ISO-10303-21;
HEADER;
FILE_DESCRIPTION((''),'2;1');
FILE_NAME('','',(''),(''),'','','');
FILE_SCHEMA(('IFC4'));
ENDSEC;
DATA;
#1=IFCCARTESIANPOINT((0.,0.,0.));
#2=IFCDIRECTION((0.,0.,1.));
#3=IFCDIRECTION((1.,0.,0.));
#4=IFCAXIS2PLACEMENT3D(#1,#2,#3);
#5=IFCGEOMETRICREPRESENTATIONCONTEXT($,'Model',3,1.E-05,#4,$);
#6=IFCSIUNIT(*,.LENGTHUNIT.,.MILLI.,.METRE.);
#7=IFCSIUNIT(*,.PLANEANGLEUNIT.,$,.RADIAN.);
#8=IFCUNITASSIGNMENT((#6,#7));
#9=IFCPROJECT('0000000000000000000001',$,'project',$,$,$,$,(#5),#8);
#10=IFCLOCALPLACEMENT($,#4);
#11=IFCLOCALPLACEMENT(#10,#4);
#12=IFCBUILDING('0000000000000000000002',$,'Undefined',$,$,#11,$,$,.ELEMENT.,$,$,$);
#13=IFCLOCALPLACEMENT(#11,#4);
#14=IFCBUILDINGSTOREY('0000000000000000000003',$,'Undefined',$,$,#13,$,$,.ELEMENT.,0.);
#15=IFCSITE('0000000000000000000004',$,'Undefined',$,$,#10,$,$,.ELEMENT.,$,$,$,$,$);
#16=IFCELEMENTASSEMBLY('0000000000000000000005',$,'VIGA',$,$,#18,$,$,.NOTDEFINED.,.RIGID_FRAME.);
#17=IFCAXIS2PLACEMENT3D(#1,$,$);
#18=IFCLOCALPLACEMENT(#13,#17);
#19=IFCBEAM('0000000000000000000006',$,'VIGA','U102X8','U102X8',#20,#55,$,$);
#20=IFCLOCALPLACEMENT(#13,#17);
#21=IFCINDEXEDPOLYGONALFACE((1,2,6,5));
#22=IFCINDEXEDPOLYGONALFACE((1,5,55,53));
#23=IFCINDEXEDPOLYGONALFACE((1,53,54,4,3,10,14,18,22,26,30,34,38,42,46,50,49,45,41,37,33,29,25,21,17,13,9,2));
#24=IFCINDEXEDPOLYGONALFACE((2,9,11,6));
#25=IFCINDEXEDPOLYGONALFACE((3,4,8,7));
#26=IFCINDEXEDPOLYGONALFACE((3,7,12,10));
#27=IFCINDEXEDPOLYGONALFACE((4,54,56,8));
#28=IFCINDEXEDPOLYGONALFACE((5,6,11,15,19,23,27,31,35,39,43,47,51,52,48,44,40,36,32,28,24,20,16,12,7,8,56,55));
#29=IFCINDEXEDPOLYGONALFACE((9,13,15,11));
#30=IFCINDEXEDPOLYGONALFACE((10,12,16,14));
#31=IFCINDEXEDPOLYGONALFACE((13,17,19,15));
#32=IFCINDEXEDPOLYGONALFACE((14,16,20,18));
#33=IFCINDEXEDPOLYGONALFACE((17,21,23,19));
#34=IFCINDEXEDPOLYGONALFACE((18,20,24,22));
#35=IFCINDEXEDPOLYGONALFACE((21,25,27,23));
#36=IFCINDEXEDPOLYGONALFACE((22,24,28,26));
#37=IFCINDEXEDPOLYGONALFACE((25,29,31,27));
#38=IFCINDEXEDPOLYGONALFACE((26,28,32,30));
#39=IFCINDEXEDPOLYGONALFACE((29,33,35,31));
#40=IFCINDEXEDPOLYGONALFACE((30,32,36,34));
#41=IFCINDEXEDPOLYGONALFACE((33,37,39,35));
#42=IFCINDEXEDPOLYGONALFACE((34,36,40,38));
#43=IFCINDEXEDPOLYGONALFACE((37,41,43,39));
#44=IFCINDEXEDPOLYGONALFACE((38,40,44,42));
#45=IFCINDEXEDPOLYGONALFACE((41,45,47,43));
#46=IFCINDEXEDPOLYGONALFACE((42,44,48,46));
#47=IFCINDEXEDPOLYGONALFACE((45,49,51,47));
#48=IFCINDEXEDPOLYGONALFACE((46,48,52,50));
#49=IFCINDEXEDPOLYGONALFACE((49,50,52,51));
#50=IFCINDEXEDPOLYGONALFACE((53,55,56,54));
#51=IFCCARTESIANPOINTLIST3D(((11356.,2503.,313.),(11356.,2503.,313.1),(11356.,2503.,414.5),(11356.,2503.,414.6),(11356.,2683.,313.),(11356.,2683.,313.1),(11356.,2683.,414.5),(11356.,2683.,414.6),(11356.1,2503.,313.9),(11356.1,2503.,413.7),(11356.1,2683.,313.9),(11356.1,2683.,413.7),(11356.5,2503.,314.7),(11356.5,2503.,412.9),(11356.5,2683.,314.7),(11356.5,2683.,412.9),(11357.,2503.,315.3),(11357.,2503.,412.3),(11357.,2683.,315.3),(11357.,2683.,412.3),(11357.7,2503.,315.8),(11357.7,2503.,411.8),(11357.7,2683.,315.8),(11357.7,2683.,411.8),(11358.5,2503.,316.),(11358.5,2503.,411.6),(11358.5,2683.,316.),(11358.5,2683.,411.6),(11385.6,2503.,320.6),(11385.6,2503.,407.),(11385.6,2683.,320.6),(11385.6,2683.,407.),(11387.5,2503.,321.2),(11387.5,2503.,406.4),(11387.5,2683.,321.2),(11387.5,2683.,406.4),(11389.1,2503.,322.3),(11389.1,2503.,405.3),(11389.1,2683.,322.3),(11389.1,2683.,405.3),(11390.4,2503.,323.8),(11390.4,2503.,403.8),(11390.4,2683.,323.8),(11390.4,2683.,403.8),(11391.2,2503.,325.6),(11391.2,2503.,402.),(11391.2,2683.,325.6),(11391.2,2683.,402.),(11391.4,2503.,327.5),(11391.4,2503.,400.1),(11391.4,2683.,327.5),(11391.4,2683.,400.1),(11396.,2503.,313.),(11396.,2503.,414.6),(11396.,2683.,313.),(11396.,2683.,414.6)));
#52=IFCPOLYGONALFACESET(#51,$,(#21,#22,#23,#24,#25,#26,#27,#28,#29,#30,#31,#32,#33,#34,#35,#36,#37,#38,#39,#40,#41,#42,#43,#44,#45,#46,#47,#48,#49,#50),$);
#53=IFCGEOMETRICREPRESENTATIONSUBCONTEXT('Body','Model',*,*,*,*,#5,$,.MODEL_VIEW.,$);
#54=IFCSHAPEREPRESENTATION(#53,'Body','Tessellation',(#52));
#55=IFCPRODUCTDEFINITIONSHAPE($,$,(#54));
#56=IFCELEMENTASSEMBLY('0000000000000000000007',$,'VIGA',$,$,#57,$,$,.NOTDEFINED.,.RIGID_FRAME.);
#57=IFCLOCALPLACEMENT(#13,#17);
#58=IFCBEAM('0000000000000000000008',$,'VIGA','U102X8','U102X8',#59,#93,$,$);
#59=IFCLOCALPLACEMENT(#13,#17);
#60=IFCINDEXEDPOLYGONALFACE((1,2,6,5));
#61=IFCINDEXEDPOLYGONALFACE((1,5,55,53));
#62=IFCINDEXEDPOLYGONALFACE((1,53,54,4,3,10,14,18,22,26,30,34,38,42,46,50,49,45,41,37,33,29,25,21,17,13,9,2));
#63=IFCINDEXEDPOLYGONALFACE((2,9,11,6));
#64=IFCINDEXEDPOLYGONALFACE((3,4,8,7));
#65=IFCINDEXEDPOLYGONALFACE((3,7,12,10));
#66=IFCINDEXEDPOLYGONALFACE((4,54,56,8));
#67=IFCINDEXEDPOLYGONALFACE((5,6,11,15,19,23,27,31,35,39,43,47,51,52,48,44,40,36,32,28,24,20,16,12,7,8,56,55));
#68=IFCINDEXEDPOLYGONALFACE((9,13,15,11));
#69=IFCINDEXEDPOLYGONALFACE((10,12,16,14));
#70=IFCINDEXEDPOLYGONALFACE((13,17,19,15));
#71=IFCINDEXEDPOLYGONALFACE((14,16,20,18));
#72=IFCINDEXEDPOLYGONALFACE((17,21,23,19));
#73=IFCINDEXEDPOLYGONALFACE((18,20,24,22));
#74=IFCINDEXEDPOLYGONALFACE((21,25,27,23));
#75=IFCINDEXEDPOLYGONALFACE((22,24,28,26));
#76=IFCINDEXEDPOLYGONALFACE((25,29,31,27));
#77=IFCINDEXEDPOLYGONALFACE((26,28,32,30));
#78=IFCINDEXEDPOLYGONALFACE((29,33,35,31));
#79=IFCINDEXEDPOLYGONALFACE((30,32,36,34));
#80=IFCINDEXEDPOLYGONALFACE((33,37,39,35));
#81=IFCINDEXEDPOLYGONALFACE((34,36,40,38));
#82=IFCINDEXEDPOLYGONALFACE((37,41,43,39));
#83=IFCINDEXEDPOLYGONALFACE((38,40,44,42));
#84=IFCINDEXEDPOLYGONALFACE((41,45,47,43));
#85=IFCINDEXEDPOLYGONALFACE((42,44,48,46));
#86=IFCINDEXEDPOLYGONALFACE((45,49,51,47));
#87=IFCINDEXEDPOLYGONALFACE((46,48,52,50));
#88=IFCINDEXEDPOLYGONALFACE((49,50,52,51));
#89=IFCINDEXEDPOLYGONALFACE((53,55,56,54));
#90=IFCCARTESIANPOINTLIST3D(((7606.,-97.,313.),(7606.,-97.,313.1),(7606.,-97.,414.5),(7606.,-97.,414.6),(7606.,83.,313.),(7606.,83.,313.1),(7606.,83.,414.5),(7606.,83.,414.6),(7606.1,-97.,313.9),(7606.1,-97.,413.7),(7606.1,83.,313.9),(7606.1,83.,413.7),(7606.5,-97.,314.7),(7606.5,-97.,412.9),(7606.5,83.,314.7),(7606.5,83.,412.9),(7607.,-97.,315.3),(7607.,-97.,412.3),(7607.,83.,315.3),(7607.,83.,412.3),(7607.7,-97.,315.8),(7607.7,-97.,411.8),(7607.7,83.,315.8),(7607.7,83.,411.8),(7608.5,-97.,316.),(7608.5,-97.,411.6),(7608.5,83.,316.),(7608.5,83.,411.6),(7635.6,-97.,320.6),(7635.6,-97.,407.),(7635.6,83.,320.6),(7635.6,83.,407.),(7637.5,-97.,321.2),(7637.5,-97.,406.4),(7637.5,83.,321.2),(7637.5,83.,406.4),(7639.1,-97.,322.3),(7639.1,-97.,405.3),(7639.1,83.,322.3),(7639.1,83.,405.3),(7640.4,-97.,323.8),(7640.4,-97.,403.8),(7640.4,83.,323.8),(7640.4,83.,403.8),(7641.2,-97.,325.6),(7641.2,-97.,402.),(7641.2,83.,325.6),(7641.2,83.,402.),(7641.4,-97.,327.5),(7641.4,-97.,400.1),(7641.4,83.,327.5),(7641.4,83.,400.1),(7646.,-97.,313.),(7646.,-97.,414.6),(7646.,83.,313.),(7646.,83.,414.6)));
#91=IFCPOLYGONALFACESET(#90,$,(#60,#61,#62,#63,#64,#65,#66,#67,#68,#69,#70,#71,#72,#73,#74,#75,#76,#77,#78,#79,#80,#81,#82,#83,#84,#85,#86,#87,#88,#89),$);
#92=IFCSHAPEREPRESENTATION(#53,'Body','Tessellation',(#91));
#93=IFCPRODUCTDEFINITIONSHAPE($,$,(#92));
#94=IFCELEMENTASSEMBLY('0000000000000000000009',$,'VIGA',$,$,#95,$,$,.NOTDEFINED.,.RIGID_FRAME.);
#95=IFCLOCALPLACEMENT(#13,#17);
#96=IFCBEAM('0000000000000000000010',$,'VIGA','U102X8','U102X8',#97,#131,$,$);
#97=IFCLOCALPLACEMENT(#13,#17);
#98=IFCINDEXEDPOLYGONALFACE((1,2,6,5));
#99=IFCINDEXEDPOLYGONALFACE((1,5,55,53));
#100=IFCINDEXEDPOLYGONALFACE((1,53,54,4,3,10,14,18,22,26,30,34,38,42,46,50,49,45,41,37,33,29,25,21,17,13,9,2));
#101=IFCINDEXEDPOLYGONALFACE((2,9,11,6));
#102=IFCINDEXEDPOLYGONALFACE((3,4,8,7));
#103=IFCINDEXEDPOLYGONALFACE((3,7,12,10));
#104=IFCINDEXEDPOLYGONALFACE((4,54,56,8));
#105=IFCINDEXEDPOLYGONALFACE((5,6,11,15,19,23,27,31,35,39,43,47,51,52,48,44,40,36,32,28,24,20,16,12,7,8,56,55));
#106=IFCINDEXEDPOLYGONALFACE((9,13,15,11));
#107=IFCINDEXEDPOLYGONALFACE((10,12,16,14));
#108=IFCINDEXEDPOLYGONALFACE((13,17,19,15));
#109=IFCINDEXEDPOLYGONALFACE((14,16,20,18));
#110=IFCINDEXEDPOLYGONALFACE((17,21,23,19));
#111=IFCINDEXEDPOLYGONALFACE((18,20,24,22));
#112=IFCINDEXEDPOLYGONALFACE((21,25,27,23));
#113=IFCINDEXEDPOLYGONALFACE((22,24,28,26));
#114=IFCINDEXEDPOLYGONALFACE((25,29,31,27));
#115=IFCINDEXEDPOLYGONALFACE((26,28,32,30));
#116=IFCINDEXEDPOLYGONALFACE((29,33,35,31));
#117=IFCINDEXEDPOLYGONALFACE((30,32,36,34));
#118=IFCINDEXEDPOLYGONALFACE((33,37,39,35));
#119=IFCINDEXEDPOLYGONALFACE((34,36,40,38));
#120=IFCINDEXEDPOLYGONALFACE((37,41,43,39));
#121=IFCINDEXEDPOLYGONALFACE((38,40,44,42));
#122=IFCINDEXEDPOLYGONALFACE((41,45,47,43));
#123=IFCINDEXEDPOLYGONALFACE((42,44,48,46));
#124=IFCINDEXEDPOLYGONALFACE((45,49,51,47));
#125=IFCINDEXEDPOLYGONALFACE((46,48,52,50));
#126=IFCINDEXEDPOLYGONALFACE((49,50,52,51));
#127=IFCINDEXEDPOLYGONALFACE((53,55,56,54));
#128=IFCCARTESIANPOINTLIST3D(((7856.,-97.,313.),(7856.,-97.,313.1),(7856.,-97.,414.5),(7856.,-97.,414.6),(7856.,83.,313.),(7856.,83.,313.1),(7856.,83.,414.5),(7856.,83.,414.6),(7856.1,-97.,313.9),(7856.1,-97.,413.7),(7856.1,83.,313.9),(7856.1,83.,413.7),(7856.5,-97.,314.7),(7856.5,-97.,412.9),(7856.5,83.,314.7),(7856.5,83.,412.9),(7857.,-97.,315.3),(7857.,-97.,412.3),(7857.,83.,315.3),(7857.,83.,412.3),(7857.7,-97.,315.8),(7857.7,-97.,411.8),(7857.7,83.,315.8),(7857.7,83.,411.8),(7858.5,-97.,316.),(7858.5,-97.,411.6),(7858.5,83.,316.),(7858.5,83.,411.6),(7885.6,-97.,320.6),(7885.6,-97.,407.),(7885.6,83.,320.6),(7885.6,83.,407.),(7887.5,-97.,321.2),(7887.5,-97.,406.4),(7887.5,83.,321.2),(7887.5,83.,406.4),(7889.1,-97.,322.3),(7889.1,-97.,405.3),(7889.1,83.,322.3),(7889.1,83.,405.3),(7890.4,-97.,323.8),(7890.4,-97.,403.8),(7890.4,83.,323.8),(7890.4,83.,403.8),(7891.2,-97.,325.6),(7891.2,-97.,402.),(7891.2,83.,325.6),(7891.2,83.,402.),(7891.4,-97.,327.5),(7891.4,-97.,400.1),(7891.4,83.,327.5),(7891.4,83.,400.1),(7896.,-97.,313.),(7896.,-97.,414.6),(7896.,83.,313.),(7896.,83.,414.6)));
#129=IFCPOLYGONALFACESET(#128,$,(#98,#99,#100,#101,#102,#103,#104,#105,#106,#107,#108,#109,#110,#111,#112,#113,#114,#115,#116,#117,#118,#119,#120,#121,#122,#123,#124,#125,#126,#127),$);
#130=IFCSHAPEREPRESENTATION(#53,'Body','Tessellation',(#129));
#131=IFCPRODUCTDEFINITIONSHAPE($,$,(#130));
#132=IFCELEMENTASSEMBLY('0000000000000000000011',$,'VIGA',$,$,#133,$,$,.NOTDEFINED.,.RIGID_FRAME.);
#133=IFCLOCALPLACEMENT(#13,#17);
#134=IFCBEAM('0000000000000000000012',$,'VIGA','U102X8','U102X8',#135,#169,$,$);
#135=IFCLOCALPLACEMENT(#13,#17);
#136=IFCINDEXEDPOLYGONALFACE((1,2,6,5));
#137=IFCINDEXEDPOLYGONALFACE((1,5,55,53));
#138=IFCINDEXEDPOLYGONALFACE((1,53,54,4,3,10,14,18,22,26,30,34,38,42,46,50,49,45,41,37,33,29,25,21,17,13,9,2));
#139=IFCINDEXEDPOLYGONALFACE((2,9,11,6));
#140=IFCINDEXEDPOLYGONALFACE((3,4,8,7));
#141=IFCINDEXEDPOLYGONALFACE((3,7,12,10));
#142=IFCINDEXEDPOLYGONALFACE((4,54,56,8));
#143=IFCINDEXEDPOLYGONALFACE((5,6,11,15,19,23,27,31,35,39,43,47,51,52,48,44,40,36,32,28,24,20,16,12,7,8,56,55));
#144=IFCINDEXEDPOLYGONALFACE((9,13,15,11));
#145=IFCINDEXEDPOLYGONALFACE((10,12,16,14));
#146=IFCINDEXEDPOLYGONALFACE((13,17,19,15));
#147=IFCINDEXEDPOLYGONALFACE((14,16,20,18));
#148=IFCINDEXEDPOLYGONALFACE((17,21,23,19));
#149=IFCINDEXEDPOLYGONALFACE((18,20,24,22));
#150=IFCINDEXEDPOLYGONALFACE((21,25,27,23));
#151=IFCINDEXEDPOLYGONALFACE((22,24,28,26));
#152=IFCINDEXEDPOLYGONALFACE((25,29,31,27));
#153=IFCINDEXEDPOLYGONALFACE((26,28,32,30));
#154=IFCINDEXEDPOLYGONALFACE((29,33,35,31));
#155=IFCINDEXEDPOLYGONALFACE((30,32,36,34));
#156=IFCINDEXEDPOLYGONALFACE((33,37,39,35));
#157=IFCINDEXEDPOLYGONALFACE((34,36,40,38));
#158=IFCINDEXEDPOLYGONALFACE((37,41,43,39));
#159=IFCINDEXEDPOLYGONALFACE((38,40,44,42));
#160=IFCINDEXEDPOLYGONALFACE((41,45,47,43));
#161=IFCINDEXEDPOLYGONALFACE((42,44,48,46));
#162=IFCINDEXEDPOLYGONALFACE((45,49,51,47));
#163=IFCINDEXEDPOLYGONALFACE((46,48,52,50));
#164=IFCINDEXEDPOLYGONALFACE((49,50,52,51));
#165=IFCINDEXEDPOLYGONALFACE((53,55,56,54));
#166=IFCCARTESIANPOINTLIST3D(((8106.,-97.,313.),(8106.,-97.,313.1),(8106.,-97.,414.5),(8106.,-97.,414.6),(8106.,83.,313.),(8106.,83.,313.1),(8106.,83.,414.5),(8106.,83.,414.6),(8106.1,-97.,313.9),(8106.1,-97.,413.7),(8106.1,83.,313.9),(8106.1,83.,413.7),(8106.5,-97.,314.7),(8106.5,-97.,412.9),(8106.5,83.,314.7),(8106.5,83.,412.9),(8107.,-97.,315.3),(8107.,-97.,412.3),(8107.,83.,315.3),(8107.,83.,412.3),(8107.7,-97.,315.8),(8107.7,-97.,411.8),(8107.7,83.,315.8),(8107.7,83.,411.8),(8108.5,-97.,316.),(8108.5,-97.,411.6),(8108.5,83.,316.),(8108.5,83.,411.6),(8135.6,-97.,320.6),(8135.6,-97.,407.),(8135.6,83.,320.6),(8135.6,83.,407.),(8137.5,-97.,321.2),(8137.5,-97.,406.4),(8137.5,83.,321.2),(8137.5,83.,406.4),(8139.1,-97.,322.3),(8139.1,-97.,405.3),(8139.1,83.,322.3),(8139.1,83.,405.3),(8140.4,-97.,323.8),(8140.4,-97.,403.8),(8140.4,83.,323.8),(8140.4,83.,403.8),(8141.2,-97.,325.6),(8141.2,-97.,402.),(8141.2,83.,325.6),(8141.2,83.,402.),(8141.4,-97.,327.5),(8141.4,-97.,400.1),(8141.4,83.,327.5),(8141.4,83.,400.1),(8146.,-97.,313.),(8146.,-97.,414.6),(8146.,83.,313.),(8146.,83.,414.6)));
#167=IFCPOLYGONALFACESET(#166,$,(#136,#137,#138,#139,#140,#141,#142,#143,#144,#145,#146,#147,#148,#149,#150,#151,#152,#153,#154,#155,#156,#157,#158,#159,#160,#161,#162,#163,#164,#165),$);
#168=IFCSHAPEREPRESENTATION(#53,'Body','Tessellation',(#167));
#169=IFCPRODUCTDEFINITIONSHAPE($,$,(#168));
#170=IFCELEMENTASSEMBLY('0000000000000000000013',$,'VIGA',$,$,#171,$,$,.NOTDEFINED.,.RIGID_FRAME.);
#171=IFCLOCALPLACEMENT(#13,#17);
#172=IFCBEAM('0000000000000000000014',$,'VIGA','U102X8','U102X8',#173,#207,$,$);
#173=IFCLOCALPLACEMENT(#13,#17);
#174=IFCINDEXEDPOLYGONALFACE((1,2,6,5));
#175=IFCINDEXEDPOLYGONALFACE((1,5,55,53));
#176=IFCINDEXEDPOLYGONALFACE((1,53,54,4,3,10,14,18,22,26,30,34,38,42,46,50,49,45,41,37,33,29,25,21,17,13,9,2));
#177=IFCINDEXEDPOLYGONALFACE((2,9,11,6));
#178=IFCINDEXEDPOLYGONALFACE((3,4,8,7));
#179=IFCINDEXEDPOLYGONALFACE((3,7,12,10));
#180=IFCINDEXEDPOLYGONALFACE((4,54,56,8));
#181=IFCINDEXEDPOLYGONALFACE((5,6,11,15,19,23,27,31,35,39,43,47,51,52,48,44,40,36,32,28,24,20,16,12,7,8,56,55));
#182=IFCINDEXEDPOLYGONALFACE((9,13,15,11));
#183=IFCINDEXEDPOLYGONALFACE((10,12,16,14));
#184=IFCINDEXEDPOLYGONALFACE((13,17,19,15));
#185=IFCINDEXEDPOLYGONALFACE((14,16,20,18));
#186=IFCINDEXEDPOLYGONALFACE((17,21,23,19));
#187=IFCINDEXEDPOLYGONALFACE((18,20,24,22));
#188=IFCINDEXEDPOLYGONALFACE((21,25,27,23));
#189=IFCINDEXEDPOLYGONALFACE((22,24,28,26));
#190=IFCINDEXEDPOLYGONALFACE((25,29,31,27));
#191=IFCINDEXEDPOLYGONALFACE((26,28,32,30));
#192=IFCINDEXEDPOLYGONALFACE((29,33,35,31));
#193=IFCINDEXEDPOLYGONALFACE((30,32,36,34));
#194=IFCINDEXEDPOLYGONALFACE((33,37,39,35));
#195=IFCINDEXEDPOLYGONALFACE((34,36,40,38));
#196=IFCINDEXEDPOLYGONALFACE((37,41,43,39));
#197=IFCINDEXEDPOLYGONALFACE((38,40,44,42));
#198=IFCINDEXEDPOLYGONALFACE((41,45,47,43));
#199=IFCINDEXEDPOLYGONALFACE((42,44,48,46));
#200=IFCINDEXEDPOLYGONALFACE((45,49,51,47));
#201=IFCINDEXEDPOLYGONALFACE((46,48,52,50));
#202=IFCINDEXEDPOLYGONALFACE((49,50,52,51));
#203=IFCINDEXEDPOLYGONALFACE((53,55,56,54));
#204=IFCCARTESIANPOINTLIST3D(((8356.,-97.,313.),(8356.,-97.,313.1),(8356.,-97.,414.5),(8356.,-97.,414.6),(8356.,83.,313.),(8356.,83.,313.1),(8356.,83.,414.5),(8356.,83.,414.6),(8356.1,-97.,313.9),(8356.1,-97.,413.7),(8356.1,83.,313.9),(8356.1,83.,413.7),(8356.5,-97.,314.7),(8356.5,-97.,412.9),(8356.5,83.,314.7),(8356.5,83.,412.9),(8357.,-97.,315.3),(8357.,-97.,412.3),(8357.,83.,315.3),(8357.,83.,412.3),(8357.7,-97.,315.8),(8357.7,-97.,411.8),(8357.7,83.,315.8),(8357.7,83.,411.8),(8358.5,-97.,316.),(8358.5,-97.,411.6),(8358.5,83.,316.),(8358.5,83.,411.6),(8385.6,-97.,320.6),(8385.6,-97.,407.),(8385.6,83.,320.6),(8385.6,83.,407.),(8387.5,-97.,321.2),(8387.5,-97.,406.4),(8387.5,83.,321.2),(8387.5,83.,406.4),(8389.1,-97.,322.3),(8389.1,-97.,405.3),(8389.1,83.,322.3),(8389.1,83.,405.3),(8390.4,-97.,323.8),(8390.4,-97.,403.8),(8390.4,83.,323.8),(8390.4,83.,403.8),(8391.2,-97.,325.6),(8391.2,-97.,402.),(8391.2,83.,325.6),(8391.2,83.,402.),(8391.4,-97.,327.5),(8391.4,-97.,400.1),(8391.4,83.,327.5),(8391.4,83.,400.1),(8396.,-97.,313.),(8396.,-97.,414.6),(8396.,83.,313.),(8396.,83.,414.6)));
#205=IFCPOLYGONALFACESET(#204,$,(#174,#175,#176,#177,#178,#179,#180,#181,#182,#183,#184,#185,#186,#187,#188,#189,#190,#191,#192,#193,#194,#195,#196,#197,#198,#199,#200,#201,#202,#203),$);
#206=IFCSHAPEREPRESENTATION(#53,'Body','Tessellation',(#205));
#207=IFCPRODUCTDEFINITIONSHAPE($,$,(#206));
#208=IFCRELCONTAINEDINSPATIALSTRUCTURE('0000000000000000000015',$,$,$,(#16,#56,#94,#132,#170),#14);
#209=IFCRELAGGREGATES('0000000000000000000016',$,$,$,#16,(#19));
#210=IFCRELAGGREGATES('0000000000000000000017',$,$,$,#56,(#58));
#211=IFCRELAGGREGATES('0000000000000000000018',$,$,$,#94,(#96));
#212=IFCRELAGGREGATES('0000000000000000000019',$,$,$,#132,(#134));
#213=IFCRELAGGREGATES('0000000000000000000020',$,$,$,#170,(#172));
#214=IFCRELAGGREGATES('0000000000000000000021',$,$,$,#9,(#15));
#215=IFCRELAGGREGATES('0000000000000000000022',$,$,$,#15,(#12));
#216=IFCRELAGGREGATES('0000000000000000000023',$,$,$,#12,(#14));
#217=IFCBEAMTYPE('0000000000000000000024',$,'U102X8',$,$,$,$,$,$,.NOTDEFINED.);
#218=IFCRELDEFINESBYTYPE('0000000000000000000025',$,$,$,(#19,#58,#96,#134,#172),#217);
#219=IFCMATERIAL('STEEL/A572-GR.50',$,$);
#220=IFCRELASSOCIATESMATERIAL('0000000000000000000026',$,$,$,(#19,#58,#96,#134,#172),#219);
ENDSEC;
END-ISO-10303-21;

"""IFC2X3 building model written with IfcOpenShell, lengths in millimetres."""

from ifc_helpers import new_model, si_unit, frame, origin_with_axes, origin_2d_with_axis, place, context, subcontext, project, spatial, u_section, extrude, material, type_object, element, aggregate, save


model = new_model("IFC2X3")

# Units and contexts
model_context = context("Model", 3, precision=1e-05, world=origin_with_axes())
body_context = subcontext(model_context, "Body", "Model", "MODEL_VIEW")
ifc_project = project(units=[si_unit("LENGTHUNIT", "METRE", prefix="MILLI"), si_unit("PLANEANGLEUNIT", "RADIAN")], contexts=[model_context])

# Site, building, storey
site_placement = place(None, origin_with_axes())
site = spatial("IfcSite", under=ifc_project, at=site_placement, Name="Undefined", CompositionType="ELEMENT")
building_placement = place(site_placement, origin_with_axes())
building = spatial("IfcBuilding", under=site, at=building_placement, Name="Undefined", CompositionType="ELEMENT")
storey_placement = place(building_placement, origin_with_axes())
storey = spatial("IfcBuildingStorey", under=building, at=storey_placement, Name="Undefined", CompositionType="ELEMENT", Elevation=0.0)

# Element assemblies, beams
ifc_material_1 = material(Name="STEEL/A572-GR.50")
beam_type = type_object("IfcBeamType", Name="U102X8", PredefinedType="NOTDEFINED")
assembly_1_placement = place(storey_placement, origin_with_axes())
assembly_1 = element("IfcElementAssembly", 1, at=assembly_1_placement, inside=storey, Name="VIGA", AssemblyPlace="NOTDEFINED", PredefinedType="RIGID_FRAME")
beam_1_placement = place(assembly_1_placement, frame((11376.0, 2683.0, 363.8), z_axis=(0.0, 0.0, 1.0), x_axis=(0.0, -1.0, 0.0)))
beam_1 = element("IfcBeam", 2, at=beam_1_placement, type_object=beam_type, material=ifc_material_1, Name="VIGA", Description="U102X8", ObjectType="U102X8", context=body_context, shape_type="SweptSolid", body=[
    extrude(u_section(Depth=101.6, FlangeWidth=40.0, WebThickness=4.6, FlangeThickness=6.0, FilletRadius=7.0, EdgeRadius=3.0, FlangeSlope=0.16839, at=origin_2d_with_axis()), frame((180.0, 0.0, 0.0), z_axis=(-1.0, 0.0, 0.0), x_axis=(0.0, -1.0, 0.0)), (0.0, 0.0, 1.0), 180.0),
])
aggregate(assembly_1, [beam_1])
assembly_2_placement = place(storey_placement, origin_with_axes())
assembly_2 = element("IfcElementAssembly", 3, at=assembly_2_placement, inside=storey, Name="VIGA", AssemblyPlace="NOTDEFINED", PredefinedType="RIGID_FRAME")
beam_2_placement = place(assembly_2_placement, frame((7626.0, 83.0, 363.8), z_axis=(0.0, 0.0, 1.0), x_axis=(0.0, -1.0, 0.0)))
beam_2 = element("IfcBeam", 4, at=beam_2_placement, type_object=beam_type, material=ifc_material_1, Name="VIGA", Description="U102X8", ObjectType="U102X8", context=body_context, shape_type="SweptSolid", body=[
    extrude(u_section(Depth=101.6, FlangeWidth=40.0, WebThickness=4.6, FlangeThickness=6.0, FilletRadius=7.0, EdgeRadius=3.0, FlangeSlope=0.16839, at=origin_2d_with_axis()), frame((180.0, 0.0, 0.0), z_axis=(-1.0, 0.0, 0.0), x_axis=(0.0, -1.0, 0.0)), (0.0, 0.0, 1.0), 180.0),
])
aggregate(assembly_2, [beam_2])
assembly_3_placement = place(storey_placement, origin_with_axes())
assembly_3 = element("IfcElementAssembly", 5, at=assembly_3_placement, inside=storey, Name="VIGA", AssemblyPlace="NOTDEFINED", PredefinedType="RIGID_FRAME")
beam_3_placement = place(assembly_3_placement, frame((7876.0, 83.0, 363.8), z_axis=(0.0, 0.0, 1.0), x_axis=(0.0, -1.0, 0.0)))
beam_3 = element("IfcBeam", 6, at=beam_3_placement, type_object=beam_type, material=ifc_material_1, Name="VIGA", Description="U102X8", ObjectType="U102X8", context=body_context, shape_type="SweptSolid", body=[
    extrude(u_section(Depth=101.6, FlangeWidth=40.0, WebThickness=4.6, FlangeThickness=6.0, FilletRadius=7.0, EdgeRadius=3.0, FlangeSlope=0.16839, at=origin_2d_with_axis()), frame((180.0, 0.0, 0.0), z_axis=(-1.0, 0.0, 0.0), x_axis=(0.0, -1.0, 0.0)), (0.0, 0.0, 1.0), 180.0),
])
aggregate(assembly_3, [beam_3])
assembly_4_placement = place(storey_placement, origin_with_axes())
assembly_4 = element("IfcElementAssembly", 7, at=assembly_4_placement, inside=storey, Name="VIGA", AssemblyPlace="NOTDEFINED", PredefinedType="RIGID_FRAME")
beam_4_placement = place(assembly_4_placement, frame((8126.0, 83.0, 363.8), z_axis=(0.0, 0.0, 1.0), x_axis=(0.0, -1.0, 0.0)))
beam_4 = element("IfcBeam", 8, at=beam_4_placement, type_object=beam_type, material=ifc_material_1, Name="VIGA", Description="U102X8", ObjectType="U102X8", context=body_context, shape_type="SweptSolid", body=[
    extrude(u_section(Depth=101.6, FlangeWidth=40.0, WebThickness=4.6, FlangeThickness=6.0, FilletRadius=7.0, EdgeRadius=3.0, FlangeSlope=0.16839, at=origin_2d_with_axis()), frame((180.0, 0.0, 0.0), z_axis=(-1.0, 0.0, 0.0), x_axis=(0.0, -1.0, 0.0)), (0.0, 0.0, 1.0), 180.0),
])
aggregate(assembly_4, [beam_4])
assembly_5_placement = place(storey_placement, origin_with_axes())
assembly_5 = element("IfcElementAssembly", 9, at=assembly_5_placement, inside=storey, Name="VIGA", AssemblyPlace="NOTDEFINED", PredefinedType="RIGID_FRAME")
beam_5_placement = place(assembly_5_placement, frame((8376.0, 83.0, 363.8), z_axis=(0.0, 0.0, 1.0), x_axis=(0.0, -1.0, 0.0)))
beam_5 = element("IfcBeam", 10, at=beam_5_placement, type_object=beam_type, material=ifc_material_1, Name="VIGA", Description="U102X8", ObjectType="U102X8", context=body_context, shape_type="SweptSolid", body=[
    extrude(u_section(Depth=101.6, FlangeWidth=40.0, WebThickness=4.6, FlangeThickness=6.0, FilletRadius=7.0, EdgeRadius=3.0, FlangeSlope=0.16839, at=origin_2d_with_axis()), frame((180.0, 0.0, 0.0), z_axis=(-1.0, 0.0, 0.0), x_axis=(0.0, -1.0, 0.0)), (0.0, 0.0, 1.0), 180.0),
])
aggregate(assembly_5, [beam_5])

save(model, "model.ifc")
